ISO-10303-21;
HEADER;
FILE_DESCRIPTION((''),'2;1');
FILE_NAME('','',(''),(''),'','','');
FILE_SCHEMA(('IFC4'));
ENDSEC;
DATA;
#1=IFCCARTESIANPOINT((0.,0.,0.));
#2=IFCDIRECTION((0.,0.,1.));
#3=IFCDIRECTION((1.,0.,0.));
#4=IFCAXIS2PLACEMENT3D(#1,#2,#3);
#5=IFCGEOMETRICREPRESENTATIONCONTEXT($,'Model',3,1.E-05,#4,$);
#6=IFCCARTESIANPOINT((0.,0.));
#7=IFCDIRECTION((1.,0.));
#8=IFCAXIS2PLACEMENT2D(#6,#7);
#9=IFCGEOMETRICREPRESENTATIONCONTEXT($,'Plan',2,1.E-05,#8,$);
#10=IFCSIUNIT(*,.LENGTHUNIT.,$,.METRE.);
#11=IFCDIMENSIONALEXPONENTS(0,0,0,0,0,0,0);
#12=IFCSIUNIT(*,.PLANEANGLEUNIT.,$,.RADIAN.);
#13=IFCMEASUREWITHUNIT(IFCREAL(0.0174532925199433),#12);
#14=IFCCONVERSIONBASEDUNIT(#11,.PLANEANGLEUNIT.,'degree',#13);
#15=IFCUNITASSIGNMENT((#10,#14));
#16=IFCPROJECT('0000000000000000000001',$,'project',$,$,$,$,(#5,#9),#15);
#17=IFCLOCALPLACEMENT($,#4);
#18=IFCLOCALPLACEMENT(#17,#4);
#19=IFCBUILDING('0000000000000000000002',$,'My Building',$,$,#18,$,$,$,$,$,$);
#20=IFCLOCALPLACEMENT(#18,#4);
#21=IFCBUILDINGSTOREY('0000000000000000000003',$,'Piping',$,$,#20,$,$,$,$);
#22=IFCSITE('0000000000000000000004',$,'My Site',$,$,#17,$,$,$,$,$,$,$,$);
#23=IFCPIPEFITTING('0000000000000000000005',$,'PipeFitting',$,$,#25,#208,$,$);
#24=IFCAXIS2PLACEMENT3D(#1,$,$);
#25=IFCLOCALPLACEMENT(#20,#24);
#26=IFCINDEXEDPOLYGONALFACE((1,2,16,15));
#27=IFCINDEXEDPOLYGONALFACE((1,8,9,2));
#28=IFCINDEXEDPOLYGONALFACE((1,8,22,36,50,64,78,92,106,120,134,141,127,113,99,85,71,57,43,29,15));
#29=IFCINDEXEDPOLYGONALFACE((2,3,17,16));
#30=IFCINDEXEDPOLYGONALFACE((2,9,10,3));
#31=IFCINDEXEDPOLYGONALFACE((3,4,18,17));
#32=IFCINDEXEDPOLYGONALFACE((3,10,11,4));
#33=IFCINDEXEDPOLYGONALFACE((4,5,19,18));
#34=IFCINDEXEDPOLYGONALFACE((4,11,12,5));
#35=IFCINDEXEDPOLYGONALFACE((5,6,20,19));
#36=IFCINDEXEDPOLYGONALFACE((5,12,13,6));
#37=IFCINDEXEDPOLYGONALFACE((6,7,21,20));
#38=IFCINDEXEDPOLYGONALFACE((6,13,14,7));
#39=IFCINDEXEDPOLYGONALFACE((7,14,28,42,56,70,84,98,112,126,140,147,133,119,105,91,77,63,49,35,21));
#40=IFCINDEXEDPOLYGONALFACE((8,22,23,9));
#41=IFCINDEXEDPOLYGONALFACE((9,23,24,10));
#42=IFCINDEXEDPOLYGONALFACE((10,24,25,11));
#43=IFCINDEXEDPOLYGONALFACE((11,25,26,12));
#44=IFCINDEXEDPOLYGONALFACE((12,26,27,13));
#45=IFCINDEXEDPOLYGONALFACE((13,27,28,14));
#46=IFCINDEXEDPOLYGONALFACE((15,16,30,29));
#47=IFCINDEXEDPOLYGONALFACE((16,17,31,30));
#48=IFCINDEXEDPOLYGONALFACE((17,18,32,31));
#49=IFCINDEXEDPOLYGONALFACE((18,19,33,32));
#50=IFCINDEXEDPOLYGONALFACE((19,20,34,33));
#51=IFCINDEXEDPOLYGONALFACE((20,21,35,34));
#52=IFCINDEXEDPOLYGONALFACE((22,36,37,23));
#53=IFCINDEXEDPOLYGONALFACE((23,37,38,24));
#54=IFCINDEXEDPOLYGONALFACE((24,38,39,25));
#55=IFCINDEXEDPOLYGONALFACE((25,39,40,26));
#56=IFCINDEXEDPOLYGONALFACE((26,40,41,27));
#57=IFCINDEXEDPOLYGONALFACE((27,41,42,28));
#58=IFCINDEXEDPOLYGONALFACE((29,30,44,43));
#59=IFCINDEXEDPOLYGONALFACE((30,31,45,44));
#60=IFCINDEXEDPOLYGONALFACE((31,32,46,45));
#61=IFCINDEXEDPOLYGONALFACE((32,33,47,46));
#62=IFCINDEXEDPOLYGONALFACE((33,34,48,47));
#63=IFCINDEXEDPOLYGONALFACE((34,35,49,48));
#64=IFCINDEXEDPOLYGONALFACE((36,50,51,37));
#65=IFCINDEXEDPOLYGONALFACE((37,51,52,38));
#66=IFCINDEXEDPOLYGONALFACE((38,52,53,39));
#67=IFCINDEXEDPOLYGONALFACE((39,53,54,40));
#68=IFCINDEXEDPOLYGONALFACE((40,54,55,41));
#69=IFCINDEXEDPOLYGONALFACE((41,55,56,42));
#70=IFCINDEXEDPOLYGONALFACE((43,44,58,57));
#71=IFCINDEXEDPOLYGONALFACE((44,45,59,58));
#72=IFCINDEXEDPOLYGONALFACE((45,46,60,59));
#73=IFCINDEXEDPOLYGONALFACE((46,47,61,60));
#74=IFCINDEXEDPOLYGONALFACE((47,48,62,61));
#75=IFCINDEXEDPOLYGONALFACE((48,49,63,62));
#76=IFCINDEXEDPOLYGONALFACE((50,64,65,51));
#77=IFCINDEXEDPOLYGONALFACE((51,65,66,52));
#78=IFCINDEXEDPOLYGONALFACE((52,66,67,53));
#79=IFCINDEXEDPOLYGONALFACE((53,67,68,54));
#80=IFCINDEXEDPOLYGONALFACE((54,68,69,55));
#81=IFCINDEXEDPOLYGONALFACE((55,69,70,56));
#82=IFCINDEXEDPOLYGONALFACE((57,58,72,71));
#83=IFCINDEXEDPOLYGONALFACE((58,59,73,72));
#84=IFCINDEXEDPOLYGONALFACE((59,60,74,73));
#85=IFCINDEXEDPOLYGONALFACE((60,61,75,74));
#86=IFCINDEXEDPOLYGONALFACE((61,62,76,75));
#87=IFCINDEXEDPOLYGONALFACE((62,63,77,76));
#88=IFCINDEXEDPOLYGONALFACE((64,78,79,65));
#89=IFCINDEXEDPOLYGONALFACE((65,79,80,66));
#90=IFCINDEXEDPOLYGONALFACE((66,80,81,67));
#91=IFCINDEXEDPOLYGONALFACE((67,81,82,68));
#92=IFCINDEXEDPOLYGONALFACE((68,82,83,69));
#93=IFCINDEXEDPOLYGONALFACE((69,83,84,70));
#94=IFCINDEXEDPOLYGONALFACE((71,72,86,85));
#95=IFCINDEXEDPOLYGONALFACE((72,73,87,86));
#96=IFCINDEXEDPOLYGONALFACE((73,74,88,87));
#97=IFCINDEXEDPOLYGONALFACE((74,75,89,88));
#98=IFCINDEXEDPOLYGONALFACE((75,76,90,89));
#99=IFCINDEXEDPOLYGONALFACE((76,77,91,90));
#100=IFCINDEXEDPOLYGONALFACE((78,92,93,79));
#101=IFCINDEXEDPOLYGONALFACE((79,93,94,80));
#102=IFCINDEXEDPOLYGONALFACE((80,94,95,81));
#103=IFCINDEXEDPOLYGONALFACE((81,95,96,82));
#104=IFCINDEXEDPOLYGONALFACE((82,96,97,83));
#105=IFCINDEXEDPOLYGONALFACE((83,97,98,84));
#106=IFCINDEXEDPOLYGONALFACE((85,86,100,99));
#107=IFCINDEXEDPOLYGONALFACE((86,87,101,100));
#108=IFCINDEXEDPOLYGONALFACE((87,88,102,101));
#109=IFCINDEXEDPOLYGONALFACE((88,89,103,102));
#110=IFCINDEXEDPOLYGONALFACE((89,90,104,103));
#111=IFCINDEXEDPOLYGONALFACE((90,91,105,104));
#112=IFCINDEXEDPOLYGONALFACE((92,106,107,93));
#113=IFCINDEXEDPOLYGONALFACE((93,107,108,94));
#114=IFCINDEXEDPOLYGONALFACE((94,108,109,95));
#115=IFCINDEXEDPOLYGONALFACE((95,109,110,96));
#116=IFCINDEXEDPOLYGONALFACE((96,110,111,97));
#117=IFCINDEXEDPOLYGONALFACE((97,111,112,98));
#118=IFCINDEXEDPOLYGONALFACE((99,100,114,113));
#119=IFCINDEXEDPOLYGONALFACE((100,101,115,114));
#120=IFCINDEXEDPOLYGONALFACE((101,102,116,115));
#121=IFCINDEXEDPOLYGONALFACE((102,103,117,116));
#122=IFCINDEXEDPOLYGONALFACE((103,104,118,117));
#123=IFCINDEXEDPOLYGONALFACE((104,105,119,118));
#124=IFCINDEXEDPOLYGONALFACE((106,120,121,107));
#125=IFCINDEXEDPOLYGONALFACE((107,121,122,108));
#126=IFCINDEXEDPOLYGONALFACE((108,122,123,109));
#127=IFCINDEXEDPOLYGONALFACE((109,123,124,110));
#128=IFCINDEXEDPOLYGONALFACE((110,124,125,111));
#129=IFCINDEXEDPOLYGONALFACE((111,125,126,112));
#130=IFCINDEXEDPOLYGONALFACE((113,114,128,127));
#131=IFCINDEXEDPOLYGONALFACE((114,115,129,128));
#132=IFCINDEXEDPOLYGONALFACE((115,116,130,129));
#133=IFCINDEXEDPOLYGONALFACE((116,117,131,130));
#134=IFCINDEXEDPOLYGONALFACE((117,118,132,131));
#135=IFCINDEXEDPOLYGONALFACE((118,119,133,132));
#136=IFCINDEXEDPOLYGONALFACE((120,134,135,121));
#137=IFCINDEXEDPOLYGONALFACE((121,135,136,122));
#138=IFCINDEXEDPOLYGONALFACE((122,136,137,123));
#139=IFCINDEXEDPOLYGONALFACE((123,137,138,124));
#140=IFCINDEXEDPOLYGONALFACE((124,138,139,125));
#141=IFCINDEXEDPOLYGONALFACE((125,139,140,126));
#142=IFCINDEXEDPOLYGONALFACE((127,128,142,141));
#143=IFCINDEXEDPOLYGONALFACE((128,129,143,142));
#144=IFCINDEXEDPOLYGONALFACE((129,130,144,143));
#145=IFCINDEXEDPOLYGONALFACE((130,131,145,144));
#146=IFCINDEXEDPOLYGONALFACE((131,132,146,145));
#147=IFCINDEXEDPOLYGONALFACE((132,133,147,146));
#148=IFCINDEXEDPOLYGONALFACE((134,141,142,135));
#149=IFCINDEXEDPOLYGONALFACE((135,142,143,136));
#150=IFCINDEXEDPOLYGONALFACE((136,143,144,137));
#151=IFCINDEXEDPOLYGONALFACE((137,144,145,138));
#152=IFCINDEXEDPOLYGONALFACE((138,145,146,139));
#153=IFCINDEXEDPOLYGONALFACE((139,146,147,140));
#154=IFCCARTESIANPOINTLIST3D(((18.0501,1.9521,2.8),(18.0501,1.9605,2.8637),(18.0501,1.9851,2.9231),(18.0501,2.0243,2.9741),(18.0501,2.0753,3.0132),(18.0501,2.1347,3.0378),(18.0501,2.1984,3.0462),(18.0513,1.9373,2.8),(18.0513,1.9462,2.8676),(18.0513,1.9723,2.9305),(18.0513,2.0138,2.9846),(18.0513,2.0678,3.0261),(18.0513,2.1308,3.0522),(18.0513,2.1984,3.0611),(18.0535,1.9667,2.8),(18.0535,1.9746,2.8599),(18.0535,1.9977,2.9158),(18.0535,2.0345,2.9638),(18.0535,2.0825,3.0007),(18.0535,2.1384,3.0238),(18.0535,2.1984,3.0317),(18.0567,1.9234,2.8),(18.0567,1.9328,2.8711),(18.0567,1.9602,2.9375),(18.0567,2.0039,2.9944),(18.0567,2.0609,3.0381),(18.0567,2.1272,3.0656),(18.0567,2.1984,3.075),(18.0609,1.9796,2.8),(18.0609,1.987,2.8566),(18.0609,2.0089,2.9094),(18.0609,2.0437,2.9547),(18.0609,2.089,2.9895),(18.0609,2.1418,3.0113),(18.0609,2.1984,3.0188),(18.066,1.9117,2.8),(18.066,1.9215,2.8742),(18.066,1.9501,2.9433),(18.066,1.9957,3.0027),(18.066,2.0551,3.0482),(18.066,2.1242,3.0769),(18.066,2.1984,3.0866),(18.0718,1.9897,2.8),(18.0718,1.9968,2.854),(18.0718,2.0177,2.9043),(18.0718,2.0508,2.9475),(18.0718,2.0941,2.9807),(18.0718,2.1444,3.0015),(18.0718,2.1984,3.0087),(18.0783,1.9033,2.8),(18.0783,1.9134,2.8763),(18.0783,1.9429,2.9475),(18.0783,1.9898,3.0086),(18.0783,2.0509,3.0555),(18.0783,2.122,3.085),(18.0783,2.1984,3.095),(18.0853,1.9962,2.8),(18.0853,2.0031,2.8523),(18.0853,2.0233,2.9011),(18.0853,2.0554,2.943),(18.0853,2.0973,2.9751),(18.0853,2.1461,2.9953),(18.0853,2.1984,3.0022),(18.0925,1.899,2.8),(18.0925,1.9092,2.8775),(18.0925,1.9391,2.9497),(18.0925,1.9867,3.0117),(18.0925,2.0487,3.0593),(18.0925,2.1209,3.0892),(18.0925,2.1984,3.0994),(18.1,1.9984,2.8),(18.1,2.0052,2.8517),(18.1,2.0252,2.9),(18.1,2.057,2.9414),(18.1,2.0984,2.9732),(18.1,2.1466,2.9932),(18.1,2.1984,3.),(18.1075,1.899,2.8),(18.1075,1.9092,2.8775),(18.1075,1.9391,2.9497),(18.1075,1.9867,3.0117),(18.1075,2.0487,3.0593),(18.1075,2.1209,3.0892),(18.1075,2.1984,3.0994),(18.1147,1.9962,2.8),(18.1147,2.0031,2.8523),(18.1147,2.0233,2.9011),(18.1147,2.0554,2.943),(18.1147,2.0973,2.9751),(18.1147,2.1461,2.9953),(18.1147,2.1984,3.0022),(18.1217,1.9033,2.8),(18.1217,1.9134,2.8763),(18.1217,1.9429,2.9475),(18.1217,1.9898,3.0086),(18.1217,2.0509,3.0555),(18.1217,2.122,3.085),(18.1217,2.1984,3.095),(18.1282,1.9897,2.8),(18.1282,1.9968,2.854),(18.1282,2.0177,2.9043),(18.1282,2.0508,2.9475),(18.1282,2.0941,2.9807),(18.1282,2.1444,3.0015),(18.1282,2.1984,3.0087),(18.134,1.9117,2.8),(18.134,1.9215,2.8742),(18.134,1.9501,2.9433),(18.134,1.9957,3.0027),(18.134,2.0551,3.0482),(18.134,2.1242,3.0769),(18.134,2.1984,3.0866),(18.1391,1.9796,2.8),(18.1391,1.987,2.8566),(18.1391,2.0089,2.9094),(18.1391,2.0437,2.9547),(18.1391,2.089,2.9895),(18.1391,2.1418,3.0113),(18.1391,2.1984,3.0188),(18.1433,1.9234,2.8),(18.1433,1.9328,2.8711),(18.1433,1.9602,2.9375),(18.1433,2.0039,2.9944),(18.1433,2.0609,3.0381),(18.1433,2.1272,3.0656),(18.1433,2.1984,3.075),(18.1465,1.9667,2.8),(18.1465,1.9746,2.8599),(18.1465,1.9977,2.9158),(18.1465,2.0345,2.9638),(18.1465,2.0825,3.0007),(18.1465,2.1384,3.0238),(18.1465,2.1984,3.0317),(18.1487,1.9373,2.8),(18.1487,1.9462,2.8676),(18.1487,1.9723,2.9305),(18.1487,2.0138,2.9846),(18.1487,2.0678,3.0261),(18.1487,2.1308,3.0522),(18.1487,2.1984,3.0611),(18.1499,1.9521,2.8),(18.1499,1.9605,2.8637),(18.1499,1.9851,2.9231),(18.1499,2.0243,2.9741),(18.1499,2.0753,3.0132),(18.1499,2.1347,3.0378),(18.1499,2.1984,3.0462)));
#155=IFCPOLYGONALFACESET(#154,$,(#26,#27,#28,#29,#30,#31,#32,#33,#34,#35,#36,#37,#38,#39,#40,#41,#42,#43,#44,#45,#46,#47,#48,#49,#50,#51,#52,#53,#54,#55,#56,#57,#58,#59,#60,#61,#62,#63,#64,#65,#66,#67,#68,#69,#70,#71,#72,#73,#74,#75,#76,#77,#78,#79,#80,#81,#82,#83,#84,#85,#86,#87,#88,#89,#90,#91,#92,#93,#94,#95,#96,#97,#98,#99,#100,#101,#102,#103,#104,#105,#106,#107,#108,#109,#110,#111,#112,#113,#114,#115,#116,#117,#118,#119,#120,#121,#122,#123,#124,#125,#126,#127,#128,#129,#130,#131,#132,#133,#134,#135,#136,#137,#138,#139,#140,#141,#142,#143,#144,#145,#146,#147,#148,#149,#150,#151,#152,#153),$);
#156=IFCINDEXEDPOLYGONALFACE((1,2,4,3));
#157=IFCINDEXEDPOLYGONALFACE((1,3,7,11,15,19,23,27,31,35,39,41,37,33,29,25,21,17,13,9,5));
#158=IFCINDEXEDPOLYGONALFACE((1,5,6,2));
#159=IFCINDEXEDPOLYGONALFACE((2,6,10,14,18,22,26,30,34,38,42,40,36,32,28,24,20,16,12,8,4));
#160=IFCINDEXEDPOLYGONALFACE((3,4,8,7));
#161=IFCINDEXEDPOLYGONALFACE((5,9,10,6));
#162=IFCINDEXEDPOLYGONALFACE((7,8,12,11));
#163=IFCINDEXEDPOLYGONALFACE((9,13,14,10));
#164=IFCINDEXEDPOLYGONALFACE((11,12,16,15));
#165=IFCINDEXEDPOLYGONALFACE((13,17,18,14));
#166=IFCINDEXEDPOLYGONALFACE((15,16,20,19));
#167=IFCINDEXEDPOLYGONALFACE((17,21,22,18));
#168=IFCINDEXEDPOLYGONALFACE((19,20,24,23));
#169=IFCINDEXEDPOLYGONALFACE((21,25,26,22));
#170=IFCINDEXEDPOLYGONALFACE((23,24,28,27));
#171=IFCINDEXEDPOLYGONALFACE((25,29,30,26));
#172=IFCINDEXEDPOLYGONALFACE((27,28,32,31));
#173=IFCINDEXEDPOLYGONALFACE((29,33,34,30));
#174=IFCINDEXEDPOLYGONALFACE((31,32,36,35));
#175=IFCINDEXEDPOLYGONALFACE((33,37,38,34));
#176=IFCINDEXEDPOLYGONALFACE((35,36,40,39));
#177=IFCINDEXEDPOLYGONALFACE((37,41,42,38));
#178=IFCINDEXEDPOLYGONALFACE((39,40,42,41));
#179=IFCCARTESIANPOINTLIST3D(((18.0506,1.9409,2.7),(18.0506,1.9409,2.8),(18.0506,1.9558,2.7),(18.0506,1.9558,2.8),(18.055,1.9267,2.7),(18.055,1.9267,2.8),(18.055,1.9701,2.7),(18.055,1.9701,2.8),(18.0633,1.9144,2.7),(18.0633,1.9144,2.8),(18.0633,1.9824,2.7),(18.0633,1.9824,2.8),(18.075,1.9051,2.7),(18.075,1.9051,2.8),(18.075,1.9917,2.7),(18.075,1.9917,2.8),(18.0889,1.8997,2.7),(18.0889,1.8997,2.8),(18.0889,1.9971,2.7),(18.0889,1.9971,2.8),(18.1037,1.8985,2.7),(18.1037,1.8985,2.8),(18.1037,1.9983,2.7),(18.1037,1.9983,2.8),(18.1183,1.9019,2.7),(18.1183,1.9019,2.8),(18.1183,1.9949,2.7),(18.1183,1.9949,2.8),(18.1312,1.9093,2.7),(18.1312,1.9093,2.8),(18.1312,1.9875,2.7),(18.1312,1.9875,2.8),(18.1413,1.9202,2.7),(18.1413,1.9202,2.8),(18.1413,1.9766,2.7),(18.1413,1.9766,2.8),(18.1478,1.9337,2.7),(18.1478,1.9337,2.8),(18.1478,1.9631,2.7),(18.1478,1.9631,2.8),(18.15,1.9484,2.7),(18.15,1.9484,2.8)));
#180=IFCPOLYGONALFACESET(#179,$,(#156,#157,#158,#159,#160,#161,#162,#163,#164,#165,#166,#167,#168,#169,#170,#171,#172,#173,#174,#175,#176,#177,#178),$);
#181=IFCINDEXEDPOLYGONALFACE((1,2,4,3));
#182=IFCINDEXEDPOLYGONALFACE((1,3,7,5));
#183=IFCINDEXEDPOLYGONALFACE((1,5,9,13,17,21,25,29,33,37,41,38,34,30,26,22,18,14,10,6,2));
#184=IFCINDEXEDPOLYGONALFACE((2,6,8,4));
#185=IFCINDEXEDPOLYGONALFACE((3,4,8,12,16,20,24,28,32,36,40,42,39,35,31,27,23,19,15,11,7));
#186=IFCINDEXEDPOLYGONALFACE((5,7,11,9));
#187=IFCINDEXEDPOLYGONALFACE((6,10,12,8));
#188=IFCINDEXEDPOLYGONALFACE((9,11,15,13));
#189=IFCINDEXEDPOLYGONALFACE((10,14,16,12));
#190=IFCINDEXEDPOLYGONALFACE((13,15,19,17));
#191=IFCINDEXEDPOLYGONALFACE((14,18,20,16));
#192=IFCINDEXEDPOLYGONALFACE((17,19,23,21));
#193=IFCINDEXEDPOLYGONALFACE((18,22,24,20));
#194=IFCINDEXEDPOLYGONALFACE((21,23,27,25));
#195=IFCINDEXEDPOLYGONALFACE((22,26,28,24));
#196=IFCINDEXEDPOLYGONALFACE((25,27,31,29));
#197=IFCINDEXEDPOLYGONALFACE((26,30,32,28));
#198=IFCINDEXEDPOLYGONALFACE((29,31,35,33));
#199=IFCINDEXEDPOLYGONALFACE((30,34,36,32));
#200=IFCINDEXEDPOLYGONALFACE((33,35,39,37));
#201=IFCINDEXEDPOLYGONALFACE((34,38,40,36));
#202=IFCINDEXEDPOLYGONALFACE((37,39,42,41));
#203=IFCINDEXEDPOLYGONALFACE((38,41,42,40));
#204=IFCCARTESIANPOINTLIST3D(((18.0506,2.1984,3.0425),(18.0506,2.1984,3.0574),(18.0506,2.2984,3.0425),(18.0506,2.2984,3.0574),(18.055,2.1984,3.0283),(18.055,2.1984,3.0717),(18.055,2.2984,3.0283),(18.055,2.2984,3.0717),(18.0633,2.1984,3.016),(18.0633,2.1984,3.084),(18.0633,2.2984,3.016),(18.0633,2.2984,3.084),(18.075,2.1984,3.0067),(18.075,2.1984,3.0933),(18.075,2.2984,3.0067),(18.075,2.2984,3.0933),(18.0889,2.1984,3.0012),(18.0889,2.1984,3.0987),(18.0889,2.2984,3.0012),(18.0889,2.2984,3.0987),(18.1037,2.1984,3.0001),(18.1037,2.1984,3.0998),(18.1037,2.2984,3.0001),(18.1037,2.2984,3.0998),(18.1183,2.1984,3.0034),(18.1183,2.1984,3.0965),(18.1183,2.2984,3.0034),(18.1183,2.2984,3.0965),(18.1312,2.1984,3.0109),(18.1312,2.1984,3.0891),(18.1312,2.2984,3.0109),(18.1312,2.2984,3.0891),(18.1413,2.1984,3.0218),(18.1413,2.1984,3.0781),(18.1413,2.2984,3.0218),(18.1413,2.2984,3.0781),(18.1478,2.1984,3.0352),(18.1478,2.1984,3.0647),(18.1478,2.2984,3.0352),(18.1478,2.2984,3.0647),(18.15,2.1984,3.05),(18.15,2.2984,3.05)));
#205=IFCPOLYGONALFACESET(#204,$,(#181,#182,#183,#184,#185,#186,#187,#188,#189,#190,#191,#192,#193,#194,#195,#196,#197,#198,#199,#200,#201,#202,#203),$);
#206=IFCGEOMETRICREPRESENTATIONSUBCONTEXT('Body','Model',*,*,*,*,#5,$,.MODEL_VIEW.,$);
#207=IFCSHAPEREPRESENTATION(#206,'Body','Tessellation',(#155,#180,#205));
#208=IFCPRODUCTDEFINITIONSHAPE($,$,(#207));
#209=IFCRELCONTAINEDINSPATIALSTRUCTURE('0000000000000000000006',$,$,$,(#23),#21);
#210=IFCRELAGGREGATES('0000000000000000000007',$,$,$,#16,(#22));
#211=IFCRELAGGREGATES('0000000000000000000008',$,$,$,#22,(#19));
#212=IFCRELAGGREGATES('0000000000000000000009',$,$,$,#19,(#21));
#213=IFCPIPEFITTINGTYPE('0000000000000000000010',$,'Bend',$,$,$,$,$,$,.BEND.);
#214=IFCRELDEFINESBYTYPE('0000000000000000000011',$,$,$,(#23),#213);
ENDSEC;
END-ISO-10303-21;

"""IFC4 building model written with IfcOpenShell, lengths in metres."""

from ifc_helpers import new_model, entity, si_unit, converted_unit, frame, origin_with_axes, origin_2d_with_axis, place, context, subcontext, project, spatial, circle, extrude, source, transform, mapped, type_object, type_shapes, element, save


model = new_model("IFC4")

# Units and contexts
model_context = context("Model", 3, precision=1e-05, world=origin_with_axes())
plan_context = context("Plan", 2, precision=1e-05, world=origin_2d_with_axis())
body_context = subcontext(model_context, "Body", "Model", "MODEL_VIEW")
ifc_project = project(units=[si_unit("LENGTHUNIT", "METRE"), converted_unit("PLANEANGLEUNIT", "degree", entity("IfcReal", 0.0174532925199433), si_unit("PLANEANGLEUNIT", "RADIAN"), dimensions=[0, 0, 0, 0, 0, 0, 0])], contexts=[model_context, plan_context])

# Site, building, storey
site_placement = place(None, origin_with_axes())
site = spatial("IfcSite", under=ifc_project, at=site_placement, Name="My Site")
building_placement = place(site_placement, origin_with_axes())
building = spatial("IfcBuilding", under=site, at=building_placement, Name="My Building")
storey_placement = place(building_placement, origin_with_axes())
storey = spatial("IfcBuildingStorey", under=building, at=storey_placement, Name="Piping")

# Pipe fitting
pipe_fitting_type_1 = type_object("IfcPipeFittingType", Name="Bend", PredefinedType="BEND")
shared_shape = source(origin_with_axes(), body_context, "Body", "SolidModel", [
    entity("IfcSweptDiskSolid", entity("IfcIndexedPolyCurve", entity("IfcCartesianPointList3D", [[0.0, 0.0, -0.1], [0.0, -0.0732, -0.2768], [0.0, -0.25, -0.35]]), [entity("IfcArcIndex", [1, 2, 3])]), 0.05),
    extrude(circle(Radius=0.05), origin_with_axes(), (0.0, 0.0, -1.0), 0.1),
    extrude(circle(Radius=0.05), frame((0.0, -0.25, -0.35), z_axis=(0.0, -1.0, 0.0), x_axis=(1.0, 0.0, 0.0)), (0.0, 0.0, 1.0), 0.1),
])
type_shapes(pipe_fitting_type_1, [shared_shape])
for number, where, z_axis, x_axis, name in (
    (1, (18.1, 1.9484, 2.7), (0.0, 0.0, -1.0), (1.0, 0.0, 0.0), "PipeFitting"),
):
    element("IfcPipeFitting", number, at=place(storey_placement, frame(where, z_axis=z_axis, x_axis=x_axis)), inside=storey, type_object=pipe_fitting_type_1, Name=name, context=body_context, shape_type="MappedRepresentation", body=[
        mapped(shared_shape, transform((0.0, 0.0, 0.0), x_axis=(1.0, 0.0, 0.0), y_axis=(0.0, 1.0, 0.0), z_axis=(0.0, 0.0, 1.0), scale=1.0)),
    ])

save(model, "model.ifc")
